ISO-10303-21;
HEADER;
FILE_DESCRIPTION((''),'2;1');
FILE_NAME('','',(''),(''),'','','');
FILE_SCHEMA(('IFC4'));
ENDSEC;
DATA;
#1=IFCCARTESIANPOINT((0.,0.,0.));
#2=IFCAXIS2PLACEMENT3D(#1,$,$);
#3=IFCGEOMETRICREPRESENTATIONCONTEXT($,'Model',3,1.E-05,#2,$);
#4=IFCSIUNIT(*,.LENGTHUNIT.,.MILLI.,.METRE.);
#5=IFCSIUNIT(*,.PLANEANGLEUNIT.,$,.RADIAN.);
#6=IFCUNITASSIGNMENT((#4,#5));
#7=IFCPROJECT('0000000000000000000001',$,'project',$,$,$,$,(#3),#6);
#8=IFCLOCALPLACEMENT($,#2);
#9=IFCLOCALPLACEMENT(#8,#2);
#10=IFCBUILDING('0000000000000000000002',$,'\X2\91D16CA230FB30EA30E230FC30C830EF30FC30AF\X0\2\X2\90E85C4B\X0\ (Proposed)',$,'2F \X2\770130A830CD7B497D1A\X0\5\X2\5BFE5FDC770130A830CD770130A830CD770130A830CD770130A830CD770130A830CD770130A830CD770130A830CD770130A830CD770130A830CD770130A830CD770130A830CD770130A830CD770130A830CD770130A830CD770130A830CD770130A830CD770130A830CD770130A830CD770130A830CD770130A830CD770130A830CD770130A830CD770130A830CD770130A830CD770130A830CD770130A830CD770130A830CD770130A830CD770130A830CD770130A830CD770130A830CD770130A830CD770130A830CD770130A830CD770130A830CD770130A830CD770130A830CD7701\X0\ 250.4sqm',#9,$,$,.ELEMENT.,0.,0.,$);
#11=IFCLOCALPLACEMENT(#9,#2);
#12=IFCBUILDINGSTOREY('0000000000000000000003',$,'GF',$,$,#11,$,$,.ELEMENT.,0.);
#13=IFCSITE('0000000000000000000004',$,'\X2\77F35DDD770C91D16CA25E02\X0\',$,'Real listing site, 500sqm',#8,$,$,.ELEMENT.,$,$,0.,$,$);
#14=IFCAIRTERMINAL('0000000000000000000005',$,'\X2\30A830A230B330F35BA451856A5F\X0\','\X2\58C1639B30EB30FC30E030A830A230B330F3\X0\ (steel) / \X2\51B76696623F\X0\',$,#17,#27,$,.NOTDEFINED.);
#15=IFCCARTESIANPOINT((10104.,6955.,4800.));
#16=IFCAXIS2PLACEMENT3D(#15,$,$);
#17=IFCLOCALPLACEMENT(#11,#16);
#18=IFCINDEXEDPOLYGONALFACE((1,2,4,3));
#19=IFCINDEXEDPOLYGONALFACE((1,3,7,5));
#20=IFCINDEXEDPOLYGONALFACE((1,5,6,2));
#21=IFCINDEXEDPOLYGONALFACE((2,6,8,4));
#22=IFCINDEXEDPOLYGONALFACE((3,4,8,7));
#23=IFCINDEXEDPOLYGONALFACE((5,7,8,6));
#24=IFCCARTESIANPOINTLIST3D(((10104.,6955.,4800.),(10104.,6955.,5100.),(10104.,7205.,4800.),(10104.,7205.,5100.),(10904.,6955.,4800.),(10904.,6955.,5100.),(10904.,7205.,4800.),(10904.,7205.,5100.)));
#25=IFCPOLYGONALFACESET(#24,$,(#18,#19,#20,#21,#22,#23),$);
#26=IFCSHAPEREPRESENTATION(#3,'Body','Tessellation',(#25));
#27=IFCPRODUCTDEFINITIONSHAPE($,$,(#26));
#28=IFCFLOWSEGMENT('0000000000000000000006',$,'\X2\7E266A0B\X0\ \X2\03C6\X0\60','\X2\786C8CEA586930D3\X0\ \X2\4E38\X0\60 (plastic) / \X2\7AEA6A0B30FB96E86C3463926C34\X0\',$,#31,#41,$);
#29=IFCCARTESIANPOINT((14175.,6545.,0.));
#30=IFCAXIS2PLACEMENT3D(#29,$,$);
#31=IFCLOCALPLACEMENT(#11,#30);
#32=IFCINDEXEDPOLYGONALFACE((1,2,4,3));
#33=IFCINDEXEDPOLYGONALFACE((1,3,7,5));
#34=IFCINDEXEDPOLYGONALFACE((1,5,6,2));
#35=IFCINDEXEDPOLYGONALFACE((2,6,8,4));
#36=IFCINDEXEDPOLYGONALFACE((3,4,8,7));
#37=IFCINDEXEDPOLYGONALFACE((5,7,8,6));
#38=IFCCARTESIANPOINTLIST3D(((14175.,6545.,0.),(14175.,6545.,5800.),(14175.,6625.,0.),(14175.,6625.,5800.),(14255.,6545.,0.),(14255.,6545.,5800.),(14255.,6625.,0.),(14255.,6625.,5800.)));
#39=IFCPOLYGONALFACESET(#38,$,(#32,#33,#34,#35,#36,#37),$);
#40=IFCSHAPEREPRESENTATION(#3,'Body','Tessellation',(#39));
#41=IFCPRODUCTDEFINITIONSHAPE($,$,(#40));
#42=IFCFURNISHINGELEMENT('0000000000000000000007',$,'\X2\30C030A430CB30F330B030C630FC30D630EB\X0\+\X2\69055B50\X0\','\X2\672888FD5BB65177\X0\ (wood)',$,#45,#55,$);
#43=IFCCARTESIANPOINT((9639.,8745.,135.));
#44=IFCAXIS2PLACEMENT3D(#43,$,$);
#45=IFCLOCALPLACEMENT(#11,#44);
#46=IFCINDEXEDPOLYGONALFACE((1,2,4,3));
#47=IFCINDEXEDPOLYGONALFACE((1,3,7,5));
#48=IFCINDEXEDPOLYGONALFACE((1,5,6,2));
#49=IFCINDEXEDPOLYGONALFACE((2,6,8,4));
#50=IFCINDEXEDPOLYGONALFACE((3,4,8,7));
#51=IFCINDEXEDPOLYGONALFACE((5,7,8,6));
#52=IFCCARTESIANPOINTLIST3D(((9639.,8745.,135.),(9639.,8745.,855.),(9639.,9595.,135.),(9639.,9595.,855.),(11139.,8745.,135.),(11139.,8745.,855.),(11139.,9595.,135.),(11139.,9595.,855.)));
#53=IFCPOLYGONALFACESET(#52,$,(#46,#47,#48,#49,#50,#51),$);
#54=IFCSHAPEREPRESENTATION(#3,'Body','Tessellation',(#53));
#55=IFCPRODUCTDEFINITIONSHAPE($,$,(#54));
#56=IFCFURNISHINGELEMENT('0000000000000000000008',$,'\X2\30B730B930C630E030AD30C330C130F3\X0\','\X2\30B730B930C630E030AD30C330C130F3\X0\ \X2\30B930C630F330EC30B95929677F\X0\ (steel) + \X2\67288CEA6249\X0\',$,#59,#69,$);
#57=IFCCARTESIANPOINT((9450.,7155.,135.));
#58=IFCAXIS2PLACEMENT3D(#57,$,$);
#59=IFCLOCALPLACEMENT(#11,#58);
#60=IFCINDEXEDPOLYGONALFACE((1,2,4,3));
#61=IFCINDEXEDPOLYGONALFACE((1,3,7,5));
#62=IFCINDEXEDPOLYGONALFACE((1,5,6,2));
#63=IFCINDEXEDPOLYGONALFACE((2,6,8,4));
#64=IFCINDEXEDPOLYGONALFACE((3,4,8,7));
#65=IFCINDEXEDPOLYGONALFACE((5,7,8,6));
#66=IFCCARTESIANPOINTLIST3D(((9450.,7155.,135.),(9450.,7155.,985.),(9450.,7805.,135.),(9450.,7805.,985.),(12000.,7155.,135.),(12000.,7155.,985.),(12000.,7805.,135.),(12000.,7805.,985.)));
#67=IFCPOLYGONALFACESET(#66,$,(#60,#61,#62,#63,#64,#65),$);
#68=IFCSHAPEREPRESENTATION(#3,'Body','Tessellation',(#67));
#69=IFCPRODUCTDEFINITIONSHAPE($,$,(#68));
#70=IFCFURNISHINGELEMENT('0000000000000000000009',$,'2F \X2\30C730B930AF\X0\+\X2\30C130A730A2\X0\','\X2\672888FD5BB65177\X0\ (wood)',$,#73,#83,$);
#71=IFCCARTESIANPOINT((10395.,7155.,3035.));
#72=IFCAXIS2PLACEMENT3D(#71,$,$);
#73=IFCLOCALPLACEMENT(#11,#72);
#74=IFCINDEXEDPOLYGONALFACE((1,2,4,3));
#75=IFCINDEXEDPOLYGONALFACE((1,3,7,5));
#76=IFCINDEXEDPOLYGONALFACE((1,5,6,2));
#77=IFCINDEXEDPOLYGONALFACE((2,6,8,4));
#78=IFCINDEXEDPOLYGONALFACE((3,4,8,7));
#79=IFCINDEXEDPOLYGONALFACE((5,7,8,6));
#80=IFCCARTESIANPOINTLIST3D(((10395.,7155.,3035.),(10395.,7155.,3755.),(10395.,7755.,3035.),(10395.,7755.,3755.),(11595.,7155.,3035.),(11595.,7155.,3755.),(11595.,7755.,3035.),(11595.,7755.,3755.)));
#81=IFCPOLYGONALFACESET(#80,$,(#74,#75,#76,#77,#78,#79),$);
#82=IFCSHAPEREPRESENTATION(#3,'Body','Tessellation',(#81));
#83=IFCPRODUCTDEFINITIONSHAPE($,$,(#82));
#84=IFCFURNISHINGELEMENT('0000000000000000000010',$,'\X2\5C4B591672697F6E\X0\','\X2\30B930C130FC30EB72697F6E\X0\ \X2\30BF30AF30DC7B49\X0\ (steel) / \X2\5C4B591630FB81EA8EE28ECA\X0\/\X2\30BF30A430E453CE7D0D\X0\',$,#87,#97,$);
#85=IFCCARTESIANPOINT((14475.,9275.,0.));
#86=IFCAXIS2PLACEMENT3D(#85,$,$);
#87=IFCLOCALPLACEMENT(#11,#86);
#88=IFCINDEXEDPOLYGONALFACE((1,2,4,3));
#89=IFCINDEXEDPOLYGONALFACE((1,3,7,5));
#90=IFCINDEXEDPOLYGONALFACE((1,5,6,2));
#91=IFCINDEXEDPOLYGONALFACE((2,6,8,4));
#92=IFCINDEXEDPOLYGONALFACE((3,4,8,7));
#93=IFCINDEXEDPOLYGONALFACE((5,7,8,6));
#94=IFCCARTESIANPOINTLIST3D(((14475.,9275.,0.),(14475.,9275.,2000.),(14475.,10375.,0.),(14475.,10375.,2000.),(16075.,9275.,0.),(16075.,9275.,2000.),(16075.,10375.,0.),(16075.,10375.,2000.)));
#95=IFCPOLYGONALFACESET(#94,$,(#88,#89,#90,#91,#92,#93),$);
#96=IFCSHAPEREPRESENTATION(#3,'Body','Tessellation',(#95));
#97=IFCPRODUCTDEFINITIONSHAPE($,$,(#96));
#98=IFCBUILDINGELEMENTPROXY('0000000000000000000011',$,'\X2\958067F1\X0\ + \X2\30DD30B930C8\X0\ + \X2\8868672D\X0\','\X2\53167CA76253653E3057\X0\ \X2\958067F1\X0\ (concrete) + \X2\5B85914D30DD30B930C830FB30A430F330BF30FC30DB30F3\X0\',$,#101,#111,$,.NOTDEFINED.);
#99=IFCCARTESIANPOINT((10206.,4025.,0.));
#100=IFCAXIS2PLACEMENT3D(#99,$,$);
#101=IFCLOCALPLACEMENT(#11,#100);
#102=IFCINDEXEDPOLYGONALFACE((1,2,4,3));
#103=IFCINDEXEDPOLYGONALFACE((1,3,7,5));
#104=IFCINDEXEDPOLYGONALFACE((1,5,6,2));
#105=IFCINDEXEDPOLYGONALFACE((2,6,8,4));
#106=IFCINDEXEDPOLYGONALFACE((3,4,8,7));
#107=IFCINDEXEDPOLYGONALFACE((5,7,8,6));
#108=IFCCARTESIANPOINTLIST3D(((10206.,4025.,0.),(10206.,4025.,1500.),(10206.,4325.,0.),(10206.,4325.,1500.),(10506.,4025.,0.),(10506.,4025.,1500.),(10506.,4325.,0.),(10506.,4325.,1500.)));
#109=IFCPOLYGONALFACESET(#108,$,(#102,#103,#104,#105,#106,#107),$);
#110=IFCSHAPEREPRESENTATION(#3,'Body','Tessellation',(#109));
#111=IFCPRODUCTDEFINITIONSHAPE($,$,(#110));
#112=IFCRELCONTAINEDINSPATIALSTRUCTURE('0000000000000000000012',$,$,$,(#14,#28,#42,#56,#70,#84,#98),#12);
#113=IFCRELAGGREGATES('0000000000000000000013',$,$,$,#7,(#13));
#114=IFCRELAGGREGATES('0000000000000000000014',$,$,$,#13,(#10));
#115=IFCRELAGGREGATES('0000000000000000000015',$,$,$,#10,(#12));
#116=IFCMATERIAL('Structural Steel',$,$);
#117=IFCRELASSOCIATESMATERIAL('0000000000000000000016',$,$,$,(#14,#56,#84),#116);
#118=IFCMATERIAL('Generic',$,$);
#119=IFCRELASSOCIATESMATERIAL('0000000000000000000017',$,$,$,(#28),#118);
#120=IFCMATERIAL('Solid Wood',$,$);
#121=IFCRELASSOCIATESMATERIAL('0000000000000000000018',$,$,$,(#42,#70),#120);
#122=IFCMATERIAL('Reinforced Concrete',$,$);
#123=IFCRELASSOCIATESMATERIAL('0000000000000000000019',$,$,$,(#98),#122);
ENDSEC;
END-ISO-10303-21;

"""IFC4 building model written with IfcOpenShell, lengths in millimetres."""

from ifc_helpers import new_model, si_unit, frame, frame_2d, origin, place, context, project, spatial, rectangle, extrude, material, element, save


model = new_model("IFC4")

# Units and contexts
model_context = context("Model", 3, precision=1e-05, world=origin())
ifc_project = project(units=[si_unit("LENGTHUNIT", "METRE", prefix="MILLI"), si_unit("PLANEANGLEUNIT", "RADIAN")], contexts=[model_context])

# Site, building, storey
site_placement = place(None, origin())
site = spatial("IfcSite", under=ifc_project, at=site_placement, Name="石川県金沢市", ObjectType="Real listing site, 500sqm", CompositionType="ELEMENT", RefElevation=0.0)
building_placement = place(site_placement, origin())
building = spatial("IfcBuilding", under=site, at=building_placement, Name="金沢・リモートワーク2部屋 (Proposed)", ObjectType="2F 省エネ等級5対応省エネ省エネ省エネ省エネ省エネ省エネ省エネ省エネ省エネ省エネ省エネ省エネ省エネ省エネ省エネ省エネ省エネ省エネ省エネ省エネ省エネ省エネ省エネ省エネ省エネ省エネ省エネ省エネ省エネ省エネ省エネ省エネ省エネ省エネ省エネ省エネ省エネ省 250.4sqm", CompositionType="ELEMENT", ElevationOfRefHeight=0.0, ElevationOfTerrain=0.0)
storey_placement = place(building_placement, origin())
storey = spatial("IfcBuildingStorey", under=building, at=storey_placement, Name="GF", CompositionType="ELEMENT", Elevation=0.0)

# Shared definitions
ifc_material_1 = material(Name="Solid Wood")

# Shared definitions
ifc_material_2 = material(Name="Reinforced Concrete")

# Shared definitions
ifc_material_3 = material(Name="Structural Steel")

# Shared definitions
ifc_material_4 = material(Name="Generic")

# Air terminal
air_terminal_placement = place(storey_placement, frame((10104.0, 6955.0, 4800.0)))
element("IfcAirTerminal", 1, at=air_terminal_placement, inside=storey, material=ifc_material_3, Name="エアコン室内機", Description="壁掛ルームエアコン (steel) / 冷暖房", PredefinedType="NOTDEFINED", context=model_context, shape_type="SweptSolid", body=[
    extrude(rectangle(XDim=800.0, YDim=250.0, at=frame_2d((400.0, 125.0))), frame((10104.0, 6955.0, 4800.0)), (0.0, 0.0, 1.0), 300.0),
])

# Flow segment
flow_segment_placement = place(storey_placement, frame((14175.0, 6545.0, 0.0)))
element("IfcFlowSegment", 2, at=flow_segment_placement, inside=storey, material=ifc_material_4, Name="縦樋 φ60", Description="硬質塩ビ 丸60 (plastic) / 竪樋・雨水排水", context=model_context, shape_type="SweptSolid", body=[
    extrude(rectangle(XDim=80.0, YDim=80.0, at=frame_2d((40.0, 40.0))), frame((14175.0, 6545.0, 0.0)), (0.0, 0.0, 1.0), 5800.0),
])

# Furnishing elements
furnishing_1_placement = place(storey_placement, frame((9639.0, 8745.0, 135.0)))
element("IfcFurnishingElement", 3, at=furnishing_1_placement, inside=storey, material=ifc_material_1, Name="ダイニングテーブル+椅子", Description="木製家具 (wood)", context=model_context, shape_type="SweptSolid", body=[
    extrude(rectangle(XDim=1500.0, YDim=850.0, at=frame_2d((750.0, 425.0))), frame((9639.0, 8745.0, 135.0)), (0.0, 0.0, 1.0), 720.0),
])
furnishing_2_placement = place(storey_placement, frame((9450.0, 7155.0, 135.0)))
element("IfcFurnishingElement", 4, at=furnishing_2_placement, inside=storey, material=ifc_material_3, Name="システムキッチン", Description="システムキッチン ステンレス天板 (steel) + 木質扉", context=model_context, shape_type="SweptSolid", body=[
    extrude(rectangle(XDim=2550.0, YDim=650.0, at=frame_2d((1275.0, 325.0))), frame((9450.0, 7155.0, 135.0)), (0.0, 0.0, 1.0), 850.0),
])
furnishing_3_placement = place(storey_placement, frame((10395.0, 7155.0, 3035.0)))
element("IfcFurnishingElement", 5, at=furnishing_3_placement, inside=storey, material=ifc_material_1, Name="2F デスク+チェア", Description="木製家具 (wood)", context=model_context, shape_type="SweptSolid", body=[
    extrude(rectangle(XDim=1200.0, YDim=600.0, at=frame_2d((600.0, 300.0))), frame((10395.0, 7155.0, 3035.0)), (0.0, 0.0, 1.0), 720.0),
])
furnishing_4_placement = place(storey_placement, frame((14475.0, 9275.0, 0.0)))
element("IfcFurnishingElement", 6, at=furnishing_4_placement, inside=storey, material=ifc_material_3, Name="屋外物置", Description="スチール物置 タクボ等 (steel) / 屋外・自転車/タイヤ収納", context=model_context, shape_type="SweptSolid", body=[
    extrude(rectangle(XDim=1600.0, YDim=1100.0, at=frame_2d((800.0, 550.0))), frame((14475.0, 9275.0, 0.0)), (0.0, 0.0, 1.0), 2000.0),
])

# Building element proxy
proxy_placement = place(storey_placement, frame((10206.0, 4025.0, 0.0)))
element("IfcBuildingElementProxy", 7, at=proxy_placement, inside=storey, material=ifc_material_2, Name="門柱 + ポスト + 表札", Description="化粧打放し 門柱 (concrete) + 宅配ポスト・インターホン", PredefinedType="NOTDEFINED", context=model_context, shape_type="SweptSolid", body=[
    extrude(rectangle(XDim=300.0, YDim=300.0, at=frame_2d((150.0, 150.0))), frame((10206.0, 4025.0, 0.0)), (0.0, 0.0, 1.0), 1500.0),
])

save(model, "model.ifc")
